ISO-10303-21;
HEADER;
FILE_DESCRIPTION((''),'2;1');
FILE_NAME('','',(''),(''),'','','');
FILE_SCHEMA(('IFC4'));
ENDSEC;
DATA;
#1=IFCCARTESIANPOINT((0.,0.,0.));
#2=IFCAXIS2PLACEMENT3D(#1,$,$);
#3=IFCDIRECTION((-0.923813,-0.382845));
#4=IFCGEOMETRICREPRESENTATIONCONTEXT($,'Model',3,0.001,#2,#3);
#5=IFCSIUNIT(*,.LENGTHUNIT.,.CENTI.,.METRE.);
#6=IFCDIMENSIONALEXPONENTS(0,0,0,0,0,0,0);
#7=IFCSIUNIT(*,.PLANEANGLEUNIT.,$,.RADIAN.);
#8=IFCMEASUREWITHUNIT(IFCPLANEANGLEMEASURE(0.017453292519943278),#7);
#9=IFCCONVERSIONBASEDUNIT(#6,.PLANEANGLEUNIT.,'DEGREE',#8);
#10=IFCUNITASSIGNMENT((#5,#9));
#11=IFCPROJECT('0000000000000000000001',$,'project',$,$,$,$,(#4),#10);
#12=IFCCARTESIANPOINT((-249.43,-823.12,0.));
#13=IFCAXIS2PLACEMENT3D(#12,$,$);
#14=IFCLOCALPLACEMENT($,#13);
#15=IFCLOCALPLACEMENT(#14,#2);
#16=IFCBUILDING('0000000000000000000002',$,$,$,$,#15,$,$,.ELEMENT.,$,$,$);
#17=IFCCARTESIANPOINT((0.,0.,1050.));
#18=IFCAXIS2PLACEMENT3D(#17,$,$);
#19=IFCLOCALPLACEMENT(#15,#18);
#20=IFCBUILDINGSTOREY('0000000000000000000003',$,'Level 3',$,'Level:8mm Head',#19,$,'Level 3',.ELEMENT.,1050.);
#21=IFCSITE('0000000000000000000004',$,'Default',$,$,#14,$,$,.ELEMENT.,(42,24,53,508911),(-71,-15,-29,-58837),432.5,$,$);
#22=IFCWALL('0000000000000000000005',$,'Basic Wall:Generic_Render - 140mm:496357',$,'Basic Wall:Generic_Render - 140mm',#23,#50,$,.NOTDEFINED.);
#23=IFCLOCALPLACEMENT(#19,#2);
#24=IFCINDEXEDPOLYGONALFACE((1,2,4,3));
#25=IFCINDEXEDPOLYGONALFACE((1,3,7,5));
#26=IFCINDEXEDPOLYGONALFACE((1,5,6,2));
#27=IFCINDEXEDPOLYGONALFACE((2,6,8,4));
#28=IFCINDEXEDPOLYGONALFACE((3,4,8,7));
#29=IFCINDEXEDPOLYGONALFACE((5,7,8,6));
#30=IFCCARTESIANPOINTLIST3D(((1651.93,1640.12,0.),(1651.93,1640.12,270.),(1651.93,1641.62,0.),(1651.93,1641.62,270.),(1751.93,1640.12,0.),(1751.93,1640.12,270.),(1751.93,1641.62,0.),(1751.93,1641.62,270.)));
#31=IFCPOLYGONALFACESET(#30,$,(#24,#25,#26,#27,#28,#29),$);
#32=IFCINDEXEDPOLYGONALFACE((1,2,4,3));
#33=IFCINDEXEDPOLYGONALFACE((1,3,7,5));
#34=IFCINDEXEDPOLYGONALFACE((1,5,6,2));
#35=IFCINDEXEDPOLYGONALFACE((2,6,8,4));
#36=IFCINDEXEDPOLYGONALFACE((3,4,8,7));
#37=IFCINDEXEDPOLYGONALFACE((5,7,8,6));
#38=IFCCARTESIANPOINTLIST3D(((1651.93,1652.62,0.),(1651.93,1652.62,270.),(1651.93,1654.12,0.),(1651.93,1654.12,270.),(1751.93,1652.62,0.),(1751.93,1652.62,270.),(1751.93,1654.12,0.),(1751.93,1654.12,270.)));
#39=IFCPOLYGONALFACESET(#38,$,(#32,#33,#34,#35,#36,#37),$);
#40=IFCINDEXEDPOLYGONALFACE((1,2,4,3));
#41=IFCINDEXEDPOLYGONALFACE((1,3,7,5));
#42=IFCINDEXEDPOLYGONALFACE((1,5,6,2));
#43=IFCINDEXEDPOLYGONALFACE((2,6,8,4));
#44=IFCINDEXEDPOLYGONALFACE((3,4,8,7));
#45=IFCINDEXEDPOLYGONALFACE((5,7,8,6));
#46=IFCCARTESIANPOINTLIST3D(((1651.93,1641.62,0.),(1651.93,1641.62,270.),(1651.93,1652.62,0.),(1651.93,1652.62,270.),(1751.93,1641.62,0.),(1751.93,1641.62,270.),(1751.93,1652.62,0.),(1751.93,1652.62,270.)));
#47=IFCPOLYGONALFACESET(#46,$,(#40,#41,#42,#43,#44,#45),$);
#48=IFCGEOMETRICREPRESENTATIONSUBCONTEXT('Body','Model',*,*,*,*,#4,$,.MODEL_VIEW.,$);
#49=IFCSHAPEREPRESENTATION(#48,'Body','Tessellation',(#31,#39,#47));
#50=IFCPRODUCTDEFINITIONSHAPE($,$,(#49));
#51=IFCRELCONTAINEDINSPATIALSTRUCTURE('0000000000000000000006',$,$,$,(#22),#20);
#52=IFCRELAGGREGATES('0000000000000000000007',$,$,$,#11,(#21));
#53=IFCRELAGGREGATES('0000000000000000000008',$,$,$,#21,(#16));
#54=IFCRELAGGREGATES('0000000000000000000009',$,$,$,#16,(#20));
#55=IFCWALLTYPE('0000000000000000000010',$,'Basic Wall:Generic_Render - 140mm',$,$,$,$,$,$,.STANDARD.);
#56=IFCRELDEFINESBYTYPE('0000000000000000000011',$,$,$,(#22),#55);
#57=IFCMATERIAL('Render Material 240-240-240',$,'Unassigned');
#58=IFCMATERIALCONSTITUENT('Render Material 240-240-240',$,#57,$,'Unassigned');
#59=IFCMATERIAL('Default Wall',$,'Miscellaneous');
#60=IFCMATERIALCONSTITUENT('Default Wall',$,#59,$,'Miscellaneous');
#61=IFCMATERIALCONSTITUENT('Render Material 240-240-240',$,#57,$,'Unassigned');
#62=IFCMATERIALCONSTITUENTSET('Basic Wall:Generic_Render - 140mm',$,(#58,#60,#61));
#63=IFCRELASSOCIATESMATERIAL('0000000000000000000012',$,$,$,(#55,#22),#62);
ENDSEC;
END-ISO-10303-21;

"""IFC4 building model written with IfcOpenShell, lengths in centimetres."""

from ifc_helpers import new_model, entity, si_unit, converted_unit, direction, frame, origin, place, context, subcontext, project, spatial, indexed_curve, outline, extrude, material, constituent, constituent_set, type_object, element, save


model = new_model("IFC4")

# Units and contexts
model_context = context("Model", 3, precision=0.001, world=origin(), true_north=direction((-0.923813, -0.382845)))
body_context = subcontext(model_context, "Body", "Model", "MODEL_VIEW")
ifc_project = project(units=[si_unit("LENGTHUNIT", "METRE", prefix="CENTI"), converted_unit("PLANEANGLEUNIT", "DEGREE", entity("IfcPlaneAngleMeasure", 0.017453292519943278), si_unit("PLANEANGLEUNIT", "RADIAN"), dimensions=[0, 0, 0, 0, 0, 0, 0])], contexts=[model_context])

# Site, building, storey
site_placement = place(None, frame((-249.43, -823.12, 0.0)))
site = spatial("IfcSite", under=ifc_project, at=site_placement, Name="Default", CompositionType="ELEMENT", RefLatitude=(42, 24, 53, 508911), RefLongitude=(-71, -15, -29, -58837), RefElevation=432.5)
building_placement = place(site_placement, origin())
building = spatial("IfcBuilding", under=site, at=building_placement, CompositionType="ELEMENT")
storey_placement = place(building_placement, frame((0.0, 0.0, 1050.0)))
storey = spatial("IfcBuildingStorey", under=building, at=storey_placement, Name="Level 3", ObjectType="Level:8mm Head", LongName="Level 3", CompositionType="ELEMENT", Elevation=1050.0)

# Shared definitions
ifc_material_1 = material(Name="Render Material 240-240-240", Category="Unassigned")
ifc_material_2 = material(Name="Default Wall", Category="Miscellaneous")

# Wall
ifc_constituent_1 = constituent(ifc_material_1, Name="Render Material 240-240-240", Category="Unassigned")
ifc_constituent_2 = constituent(ifc_material_2, Name="Default Wall", Category="Miscellaneous")
ifc_constituent_3 = constituent(ifc_material_1, Name="Render Material 240-240-240", Category="Unassigned")
ifc_constituent_set_1 = constituent_set(constituents=[ifc_constituent_1, ifc_constituent_2, ifc_constituent_3], Name="Basic Wall:Generic_Render - 140mm")
wall_type_1 = type_object("IfcWallType", Name="Basic Wall:Generic_Render - 140mm", PredefinedType="STANDARD", material=ifc_constituent_set_1)
wall_1_placement = place(storey_placement, frame((1651.93, 1647.12, 0.0)))
element("IfcWall", 1, at=wall_1_placement, inside=storey, type_object=wall_type_1, material=ifc_constituent_set_1, Name="Basic Wall:Generic_Render - 140mm:496357", ObjectType="Basic Wall:Generic_Render - 140mm", PredefinedType="NOTDEFINED", context=body_context, shape_type="SweptSolid", body=[
    extrude(outline(indexed_curve([(-0.75, -50.0), (0.75, -50.0), (0.75, 50.0), (-0.75, 50.0), (-0.75, -50.0)], self_intersect=False)), frame((50.0, -6.25, 0.0), z_axis=(0.0, 0.0, 1.0), x_axis=(0.0, 1.0, 0.0)), (0.0, 0.0, 1.0), 270.0),
    extrude(outline(indexed_curve([(-0.75, -50.0), (0.75, -50.0), (0.75, 50.0), (-0.75, 50.0), (-0.75, -50.0)], self_intersect=False)), frame((50.0, 6.25, 0.0), z_axis=(0.0, 0.0, 1.0), x_axis=(0.0, -1.0, 0.0)), (0.0, 0.0, 1.0), 270.0),
    extrude(outline(indexed_curve([(-50.0, -5.5), (50.0, -5.5), (50.0, 5.5), (-50.0, 5.5), (-50.0, -5.5)], self_intersect=False)), frame((50.0, 0.0, 0.0)), (0.0, 0.0, 1.0), 270.0),
])

save(model, "model.ifc")
